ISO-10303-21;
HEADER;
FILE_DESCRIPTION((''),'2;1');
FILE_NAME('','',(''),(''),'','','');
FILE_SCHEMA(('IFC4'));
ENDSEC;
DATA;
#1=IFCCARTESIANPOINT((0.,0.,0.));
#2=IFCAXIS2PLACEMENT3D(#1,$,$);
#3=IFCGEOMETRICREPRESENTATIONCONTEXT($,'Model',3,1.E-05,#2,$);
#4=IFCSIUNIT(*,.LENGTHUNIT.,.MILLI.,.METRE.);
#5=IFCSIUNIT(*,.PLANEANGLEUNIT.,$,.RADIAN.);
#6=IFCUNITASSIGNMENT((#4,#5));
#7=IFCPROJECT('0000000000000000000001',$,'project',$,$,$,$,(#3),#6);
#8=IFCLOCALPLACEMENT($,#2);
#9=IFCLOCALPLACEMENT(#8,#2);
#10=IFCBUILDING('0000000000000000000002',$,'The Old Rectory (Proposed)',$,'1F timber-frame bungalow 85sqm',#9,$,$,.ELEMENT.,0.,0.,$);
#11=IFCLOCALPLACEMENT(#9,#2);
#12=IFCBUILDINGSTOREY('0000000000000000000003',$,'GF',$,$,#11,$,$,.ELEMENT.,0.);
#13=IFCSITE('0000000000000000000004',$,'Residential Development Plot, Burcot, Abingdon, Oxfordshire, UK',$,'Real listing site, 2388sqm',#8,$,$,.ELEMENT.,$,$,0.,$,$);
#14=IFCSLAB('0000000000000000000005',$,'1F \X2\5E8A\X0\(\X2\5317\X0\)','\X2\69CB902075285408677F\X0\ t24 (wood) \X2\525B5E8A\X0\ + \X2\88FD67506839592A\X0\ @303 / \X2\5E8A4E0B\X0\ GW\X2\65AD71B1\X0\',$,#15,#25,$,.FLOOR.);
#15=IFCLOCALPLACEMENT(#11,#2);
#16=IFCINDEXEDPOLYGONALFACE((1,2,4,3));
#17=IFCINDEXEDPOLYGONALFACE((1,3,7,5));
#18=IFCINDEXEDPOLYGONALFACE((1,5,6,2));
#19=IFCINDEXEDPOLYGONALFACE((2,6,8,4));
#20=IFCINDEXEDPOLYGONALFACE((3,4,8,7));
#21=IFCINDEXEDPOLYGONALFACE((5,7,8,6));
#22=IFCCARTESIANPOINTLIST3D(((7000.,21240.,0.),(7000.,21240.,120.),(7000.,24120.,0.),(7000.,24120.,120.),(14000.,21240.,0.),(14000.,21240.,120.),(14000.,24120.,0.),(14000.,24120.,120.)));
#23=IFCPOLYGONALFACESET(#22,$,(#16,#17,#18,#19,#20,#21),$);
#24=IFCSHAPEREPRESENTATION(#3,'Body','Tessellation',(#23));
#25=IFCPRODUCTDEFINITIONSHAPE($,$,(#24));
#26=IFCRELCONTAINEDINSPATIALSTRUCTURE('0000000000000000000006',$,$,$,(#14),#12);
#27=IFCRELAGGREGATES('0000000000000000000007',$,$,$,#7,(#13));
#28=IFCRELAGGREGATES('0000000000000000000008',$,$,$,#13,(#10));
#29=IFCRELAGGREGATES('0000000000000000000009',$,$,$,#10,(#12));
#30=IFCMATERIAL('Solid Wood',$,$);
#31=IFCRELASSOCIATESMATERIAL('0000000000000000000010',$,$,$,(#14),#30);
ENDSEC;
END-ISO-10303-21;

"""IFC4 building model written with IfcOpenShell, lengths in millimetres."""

from ifc_helpers import new_model, si_unit, frame, frame_2d, origin, place, context, project, spatial, rectangle, extrude, material, element, save


model = new_model("IFC4")

# Units and contexts
model_context = context("Model", 3, precision=1e-05, world=origin())
ifc_project = project(units=[si_unit("LENGTHUNIT", "METRE", prefix="MILLI"), si_unit("PLANEANGLEUNIT", "RADIAN")], contexts=[model_context])

# Site, building, storey
site_placement = place(None, origin())
site = spatial("IfcSite", under=ifc_project, at=site_placement, Name="Residential Development Plot, Burcot, Abingdon, Oxfordshire, UK", ObjectType="Real listing site, 2388sqm", CompositionType="ELEMENT", RefElevation=0.0)
building_placement = place(site_placement, origin())
building = spatial("IfcBuilding", under=site, at=building_placement, Name="The Old Rectory (Proposed)", ObjectType="1F timber-frame bungalow 85sqm", CompositionType="ELEMENT", ElevationOfRefHeight=0.0, ElevationOfTerrain=0.0)
storey_placement = place(building_placement, origin())
storey = spatial("IfcBuildingStorey", under=building, at=storey_placement, Name="GF", CompositionType="ELEMENT", Elevation=0.0)

# Slab
ifc_material_1 = material(Name="Solid Wood")
slab_1_placement = place(storey_placement, frame((3500.0, 10620.0, 0.0)))
element("IfcSlab", 1, at=slab_1_placement, inside=storey, material=ifc_material_1, Name="1F 床(北)", Description="構造用合板 t24 (wood) 剛床 + 製材根太 @303 / 床下 GW断熱", PredefinedType="FLOOR", context=model_context, shape_type="SweptSolid", body=[
    extrude(rectangle(XDim=7000.0, YDim=2880.0, at=frame_2d((3500.0, 1440.0))), frame((3500.0, 10620.0, 0.0)), (0.0, 0.0, 1.0), 120.0),
])

save(model, "model.ifc")
